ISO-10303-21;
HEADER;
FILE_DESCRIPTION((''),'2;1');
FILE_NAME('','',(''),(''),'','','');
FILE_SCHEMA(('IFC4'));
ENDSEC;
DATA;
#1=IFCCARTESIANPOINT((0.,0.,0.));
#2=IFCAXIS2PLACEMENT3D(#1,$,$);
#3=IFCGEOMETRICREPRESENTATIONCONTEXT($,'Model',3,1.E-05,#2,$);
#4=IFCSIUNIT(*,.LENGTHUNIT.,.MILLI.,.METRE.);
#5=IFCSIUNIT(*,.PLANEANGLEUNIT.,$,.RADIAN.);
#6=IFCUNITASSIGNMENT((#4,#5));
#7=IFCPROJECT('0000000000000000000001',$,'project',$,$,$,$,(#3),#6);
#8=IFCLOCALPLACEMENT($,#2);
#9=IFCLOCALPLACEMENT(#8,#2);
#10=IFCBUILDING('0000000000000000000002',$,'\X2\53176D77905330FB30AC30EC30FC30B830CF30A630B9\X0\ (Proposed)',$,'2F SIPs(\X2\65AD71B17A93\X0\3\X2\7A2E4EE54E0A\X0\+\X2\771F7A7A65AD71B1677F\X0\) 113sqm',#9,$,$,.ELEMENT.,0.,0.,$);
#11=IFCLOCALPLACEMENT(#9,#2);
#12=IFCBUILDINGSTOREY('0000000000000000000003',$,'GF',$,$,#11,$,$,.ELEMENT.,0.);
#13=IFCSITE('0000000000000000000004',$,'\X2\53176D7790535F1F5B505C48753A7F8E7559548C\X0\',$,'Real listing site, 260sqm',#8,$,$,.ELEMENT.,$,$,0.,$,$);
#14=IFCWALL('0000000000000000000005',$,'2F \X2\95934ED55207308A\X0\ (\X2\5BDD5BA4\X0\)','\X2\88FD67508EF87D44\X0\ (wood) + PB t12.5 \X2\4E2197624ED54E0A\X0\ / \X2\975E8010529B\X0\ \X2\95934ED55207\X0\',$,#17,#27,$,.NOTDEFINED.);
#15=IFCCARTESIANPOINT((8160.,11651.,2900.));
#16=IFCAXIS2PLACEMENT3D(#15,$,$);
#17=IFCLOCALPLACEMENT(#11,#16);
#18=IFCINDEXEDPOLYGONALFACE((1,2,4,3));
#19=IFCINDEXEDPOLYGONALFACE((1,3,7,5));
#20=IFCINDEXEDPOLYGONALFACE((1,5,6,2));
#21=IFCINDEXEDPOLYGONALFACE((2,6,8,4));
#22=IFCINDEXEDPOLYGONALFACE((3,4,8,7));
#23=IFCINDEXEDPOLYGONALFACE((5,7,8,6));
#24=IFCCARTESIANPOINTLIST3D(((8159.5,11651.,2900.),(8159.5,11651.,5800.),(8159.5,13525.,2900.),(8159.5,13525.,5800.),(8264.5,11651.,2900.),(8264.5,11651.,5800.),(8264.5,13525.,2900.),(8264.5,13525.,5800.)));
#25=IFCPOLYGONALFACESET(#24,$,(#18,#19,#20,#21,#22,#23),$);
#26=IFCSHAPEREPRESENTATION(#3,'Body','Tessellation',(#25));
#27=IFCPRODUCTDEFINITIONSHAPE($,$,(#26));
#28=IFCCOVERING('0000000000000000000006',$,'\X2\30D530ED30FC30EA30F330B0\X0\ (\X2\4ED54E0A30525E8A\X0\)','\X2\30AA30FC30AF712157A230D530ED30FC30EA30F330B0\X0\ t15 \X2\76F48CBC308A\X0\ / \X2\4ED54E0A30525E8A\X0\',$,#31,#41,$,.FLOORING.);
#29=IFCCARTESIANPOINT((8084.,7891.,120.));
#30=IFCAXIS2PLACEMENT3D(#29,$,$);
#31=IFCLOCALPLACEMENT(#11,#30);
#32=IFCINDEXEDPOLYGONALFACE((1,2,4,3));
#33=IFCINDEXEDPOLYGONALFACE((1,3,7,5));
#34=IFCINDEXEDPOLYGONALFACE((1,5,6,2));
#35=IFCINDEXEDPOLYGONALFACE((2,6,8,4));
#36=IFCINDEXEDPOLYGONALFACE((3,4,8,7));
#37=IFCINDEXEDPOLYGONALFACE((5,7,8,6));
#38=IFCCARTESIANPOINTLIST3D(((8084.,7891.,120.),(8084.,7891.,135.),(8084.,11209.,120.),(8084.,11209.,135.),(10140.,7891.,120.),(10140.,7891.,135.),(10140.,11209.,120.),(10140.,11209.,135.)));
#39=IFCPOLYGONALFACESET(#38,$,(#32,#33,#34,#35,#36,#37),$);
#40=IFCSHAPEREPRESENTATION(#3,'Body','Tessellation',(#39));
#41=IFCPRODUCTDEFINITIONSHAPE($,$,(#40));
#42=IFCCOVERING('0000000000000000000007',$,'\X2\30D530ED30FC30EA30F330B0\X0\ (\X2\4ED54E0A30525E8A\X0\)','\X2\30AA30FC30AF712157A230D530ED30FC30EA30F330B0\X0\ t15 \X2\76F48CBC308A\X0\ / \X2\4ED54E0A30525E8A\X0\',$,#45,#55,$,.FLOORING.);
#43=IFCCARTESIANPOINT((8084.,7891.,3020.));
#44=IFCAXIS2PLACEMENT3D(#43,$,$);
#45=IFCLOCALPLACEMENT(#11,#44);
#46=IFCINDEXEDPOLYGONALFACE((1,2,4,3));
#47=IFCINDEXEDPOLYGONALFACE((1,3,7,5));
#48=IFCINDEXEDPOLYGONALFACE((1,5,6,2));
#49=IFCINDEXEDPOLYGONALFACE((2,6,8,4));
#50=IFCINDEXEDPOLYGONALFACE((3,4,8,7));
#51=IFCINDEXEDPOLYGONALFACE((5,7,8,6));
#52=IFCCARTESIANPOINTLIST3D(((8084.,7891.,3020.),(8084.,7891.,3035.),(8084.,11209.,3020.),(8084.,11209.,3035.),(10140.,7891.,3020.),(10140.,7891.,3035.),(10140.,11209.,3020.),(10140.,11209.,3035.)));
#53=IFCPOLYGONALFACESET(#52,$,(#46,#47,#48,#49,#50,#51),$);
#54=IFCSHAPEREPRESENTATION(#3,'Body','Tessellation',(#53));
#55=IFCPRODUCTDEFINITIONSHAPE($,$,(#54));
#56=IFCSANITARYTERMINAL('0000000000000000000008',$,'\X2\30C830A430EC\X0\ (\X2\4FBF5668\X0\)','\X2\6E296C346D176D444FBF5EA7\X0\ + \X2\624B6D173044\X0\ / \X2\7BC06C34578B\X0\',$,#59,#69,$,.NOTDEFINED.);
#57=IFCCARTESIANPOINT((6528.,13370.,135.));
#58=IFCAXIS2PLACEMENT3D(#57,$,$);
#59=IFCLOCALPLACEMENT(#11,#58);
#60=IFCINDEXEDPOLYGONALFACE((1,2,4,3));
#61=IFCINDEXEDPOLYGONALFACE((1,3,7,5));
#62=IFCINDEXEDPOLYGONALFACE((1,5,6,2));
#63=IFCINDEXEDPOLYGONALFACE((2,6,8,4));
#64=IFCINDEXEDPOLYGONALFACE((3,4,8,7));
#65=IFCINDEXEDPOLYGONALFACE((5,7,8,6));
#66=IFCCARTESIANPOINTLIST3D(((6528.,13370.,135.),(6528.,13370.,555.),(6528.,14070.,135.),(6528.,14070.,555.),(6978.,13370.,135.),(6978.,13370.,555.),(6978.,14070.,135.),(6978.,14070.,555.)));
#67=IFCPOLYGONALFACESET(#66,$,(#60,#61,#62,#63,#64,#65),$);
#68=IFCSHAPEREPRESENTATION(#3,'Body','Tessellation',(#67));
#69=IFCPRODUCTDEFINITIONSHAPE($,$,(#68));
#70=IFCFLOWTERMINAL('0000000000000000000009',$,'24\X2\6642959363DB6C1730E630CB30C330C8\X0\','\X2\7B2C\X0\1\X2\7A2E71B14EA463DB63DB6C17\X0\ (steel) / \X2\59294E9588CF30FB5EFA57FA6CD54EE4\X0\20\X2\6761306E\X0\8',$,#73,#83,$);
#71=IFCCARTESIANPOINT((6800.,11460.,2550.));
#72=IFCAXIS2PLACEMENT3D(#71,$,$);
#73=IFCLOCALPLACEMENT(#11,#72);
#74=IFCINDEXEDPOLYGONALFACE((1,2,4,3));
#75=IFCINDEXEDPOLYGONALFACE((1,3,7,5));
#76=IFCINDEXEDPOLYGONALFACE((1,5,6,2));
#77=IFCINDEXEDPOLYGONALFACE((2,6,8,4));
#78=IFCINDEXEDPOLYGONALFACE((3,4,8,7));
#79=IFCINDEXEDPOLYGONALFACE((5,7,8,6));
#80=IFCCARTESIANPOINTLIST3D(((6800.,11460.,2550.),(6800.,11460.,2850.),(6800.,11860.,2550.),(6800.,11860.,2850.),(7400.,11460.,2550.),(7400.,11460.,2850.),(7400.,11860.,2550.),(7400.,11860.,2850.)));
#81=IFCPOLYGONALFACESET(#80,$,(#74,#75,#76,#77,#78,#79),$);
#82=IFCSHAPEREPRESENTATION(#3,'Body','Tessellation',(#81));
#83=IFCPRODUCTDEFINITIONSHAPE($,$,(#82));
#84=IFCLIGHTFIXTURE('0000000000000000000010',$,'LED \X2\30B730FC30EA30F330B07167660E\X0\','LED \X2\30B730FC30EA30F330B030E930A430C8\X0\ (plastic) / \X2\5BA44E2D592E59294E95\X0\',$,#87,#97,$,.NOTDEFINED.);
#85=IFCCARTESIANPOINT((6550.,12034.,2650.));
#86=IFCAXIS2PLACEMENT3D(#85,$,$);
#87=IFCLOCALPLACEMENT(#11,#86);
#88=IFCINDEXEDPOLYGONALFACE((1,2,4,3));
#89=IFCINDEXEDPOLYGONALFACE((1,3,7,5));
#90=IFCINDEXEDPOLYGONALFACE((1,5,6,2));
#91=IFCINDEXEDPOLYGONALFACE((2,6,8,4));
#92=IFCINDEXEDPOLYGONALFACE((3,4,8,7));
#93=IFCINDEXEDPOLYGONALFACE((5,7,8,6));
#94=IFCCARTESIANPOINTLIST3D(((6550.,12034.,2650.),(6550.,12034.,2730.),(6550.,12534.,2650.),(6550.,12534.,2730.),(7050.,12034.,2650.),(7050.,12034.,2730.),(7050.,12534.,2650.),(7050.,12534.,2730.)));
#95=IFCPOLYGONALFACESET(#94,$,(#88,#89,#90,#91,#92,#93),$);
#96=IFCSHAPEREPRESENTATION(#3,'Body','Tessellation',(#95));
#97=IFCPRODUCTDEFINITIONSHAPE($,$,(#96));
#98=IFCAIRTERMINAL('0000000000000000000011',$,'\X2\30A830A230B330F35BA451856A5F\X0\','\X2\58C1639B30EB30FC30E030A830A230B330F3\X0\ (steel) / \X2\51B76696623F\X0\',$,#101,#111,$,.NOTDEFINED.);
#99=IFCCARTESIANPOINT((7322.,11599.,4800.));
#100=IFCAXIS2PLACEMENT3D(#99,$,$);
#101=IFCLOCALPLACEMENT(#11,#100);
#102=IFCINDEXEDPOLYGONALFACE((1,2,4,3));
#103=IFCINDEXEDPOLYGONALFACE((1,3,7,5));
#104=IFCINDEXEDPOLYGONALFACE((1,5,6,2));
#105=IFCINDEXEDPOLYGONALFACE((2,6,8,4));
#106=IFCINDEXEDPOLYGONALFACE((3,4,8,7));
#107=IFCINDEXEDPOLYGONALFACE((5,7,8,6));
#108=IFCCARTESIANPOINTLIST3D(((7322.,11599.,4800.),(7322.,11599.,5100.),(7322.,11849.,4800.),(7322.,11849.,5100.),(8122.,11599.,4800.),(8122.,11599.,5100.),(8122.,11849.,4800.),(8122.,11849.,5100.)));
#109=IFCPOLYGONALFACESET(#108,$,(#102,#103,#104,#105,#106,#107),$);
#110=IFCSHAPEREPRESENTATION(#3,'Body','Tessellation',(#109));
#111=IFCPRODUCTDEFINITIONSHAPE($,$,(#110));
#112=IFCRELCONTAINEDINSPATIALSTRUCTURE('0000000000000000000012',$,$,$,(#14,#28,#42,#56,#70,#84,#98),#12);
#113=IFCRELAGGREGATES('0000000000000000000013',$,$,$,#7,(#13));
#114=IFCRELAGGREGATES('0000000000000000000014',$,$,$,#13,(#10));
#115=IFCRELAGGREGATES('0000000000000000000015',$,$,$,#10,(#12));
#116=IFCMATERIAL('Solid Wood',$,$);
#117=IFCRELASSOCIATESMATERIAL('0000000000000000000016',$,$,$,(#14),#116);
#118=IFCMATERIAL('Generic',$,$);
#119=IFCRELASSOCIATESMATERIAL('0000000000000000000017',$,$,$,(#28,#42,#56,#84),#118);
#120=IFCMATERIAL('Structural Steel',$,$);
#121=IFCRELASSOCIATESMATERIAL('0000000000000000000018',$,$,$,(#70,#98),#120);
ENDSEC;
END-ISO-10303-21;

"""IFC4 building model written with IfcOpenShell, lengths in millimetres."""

from ifc_helpers import new_model, si_unit, frame, frame_2d, origin, place, context, project, spatial, rectangle, extrude, material, element, save


model = new_model("IFC4")

# Units and contexts
model_context = context("Model", 3, precision=1e-05, world=origin())
ifc_project = project(units=[si_unit("LENGTHUNIT", "METRE", prefix="MILLI"), si_unit("PLANEANGLEUNIT", "RADIAN")], contexts=[model_context])

# Site, building, storey
site_placement = place(None, origin())
site = spatial("IfcSite", under=ifc_project, at=site_placement, Name="北海道弟子屈町美留和", ObjectType="Real listing site, 260sqm", CompositionType="ELEMENT", RefElevation=0.0)
building_placement = place(site_placement, origin())
building = spatial("IfcBuilding", under=site, at=building_placement, Name="北海道・ガレージハウス (Proposed)", ObjectType="2F SIPs(断熱窓3種以上+真空断熱板) 113sqm", CompositionType="ELEMENT", ElevationOfRefHeight=0.0, ElevationOfTerrain=0.0)
storey_placement = place(building_placement, origin())
storey = spatial("IfcBuildingStorey", under=building, at=storey_placement, Name="GF", CompositionType="ELEMENT", Elevation=0.0)

# Shared definitions
ifc_material_1 = material(Name="Solid Wood")

# Wall
wall_1_placement = place(storey_placement, frame((8160.0, 11651.0, 2900.0)))
element("IfcWall", 1, at=wall_1_placement, inside=storey, material=ifc_material_1, Name="2F 間仕切り (寝室)", Description="製材軸組 (wood) + PB t12.5 両面仕上 / 非耐力 間仕切", PredefinedType="NOTDEFINED", context=model_context, shape_type="SweptSolid", body=[
    extrude(rectangle(XDim=105.0, YDim=1874.0, at=frame_2d((52.0, 937.0))), frame((8160.0, 11651.0, 2900.0)), (0.0, 0.0, 1.0), 2900.0),
])

# Coverings
ifc_material_2 = material(Name="Generic")
covering_1_placement = place(storey_placement, frame((8084.0, 7891.0, 120.0)))
element("IfcCovering", 2, at=covering_1_placement, inside=storey, material=ifc_material_2, Name="フローリング (仕上げ床)", Description="オーク無垢フローリング t15 直貼り / 仕上げ床", PredefinedType="FLOORING", context=model_context, shape_type="SweptSolid", body=[
    extrude(rectangle(XDim=2056.0, YDim=3318.0, at=frame_2d((1028.0, 1659.0))), frame((8084.0, 7891.0, 120.0)), (0.0, 0.0, 1.0), 15.0),
])
covering_2_placement = place(storey_placement, frame((8084.0, 7891.0, 3020.0)))
element("IfcCovering", 3, at=covering_2_placement, inside=storey, material=ifc_material_2, Name="フローリング (仕上げ床)", Description="オーク無垢フローリング t15 直貼り / 仕上げ床", PredefinedType="FLOORING", context=model_context, shape_type="SweptSolid", body=[
    extrude(rectangle(XDim=2056.0, YDim=3318.0, at=frame_2d((1028.0, 1659.0))), frame((8084.0, 7891.0, 3020.0)), (0.0, 0.0, 1.0), 15.0),
])

# Sanitary terminal
sanitary_terminal_placement = place(storey_placement, frame((6528.0, 13370.0, 135.0)))
element("IfcSanitaryTerminal", 4, at=sanitary_terminal_placement, inside=storey, material=ifc_material_2, Name="トイレ (便器)", Description="温水洗浄便座 + 手洗い / 節水型", PredefinedType="NOTDEFINED", context=model_context, shape_type="SweptSolid", body=[
    extrude(rectangle(XDim=450.0, YDim=700.0, at=frame_2d((225.0, 350.0))), frame((6528.0, 13370.0, 135.0)), (0.0, 0.0, 1.0), 420.0),
])

# Flow terminal
ifc_material_3 = material(Name="Structural Steel")
flow_terminal_placement = place(storey_placement, frame((6800.0, 11460.0, 2550.0)))
element("IfcFlowTerminal", 5, at=flow_terminal_placement, inside=storey, material=ifc_material_3, Name="24時間換気ユニット", Description="第1種熱交換換気 (steel) / 天井裏・建基法令20条の8", context=model_context, shape_type="SweptSolid", body=[
    extrude(rectangle(XDim=600.0, YDim=400.0, at=frame_2d((300.0, 200.0))), frame((6800.0, 11460.0, 2550.0)), (0.0, 0.0, 1.0), 300.0),
])

# Light fixture
light_fixture_placement = place(storey_placement, frame((6550.0, 12034.0, 2650.0)))
element("IfcLightFixture", 6, at=light_fixture_placement, inside=storey, material=ifc_material_2, Name="LED シーリング照明", Description="LED シーリングライト (plastic) / 室中央天井", PredefinedType="NOTDEFINED", context=model_context, shape_type="SweptSolid", body=[
    extrude(rectangle(XDim=500.0, YDim=500.0, at=frame_2d((250.0, 250.0))), frame((6550.0, 12034.0, 2650.0)), (0.0, 0.0, 1.0), 80.0),
])

# Air terminal
air_terminal_placement = place(storey_placement, frame((7322.0, 11599.0, 4800.0)))
element("IfcAirTerminal", 7, at=air_terminal_placement, inside=storey, material=ifc_material_3, Name="エアコン室内機", Description="壁掛ルームエアコン (steel) / 冷暖房", PredefinedType="NOTDEFINED", context=model_context, shape_type="SweptSolid", body=[
    extrude(rectangle(XDim=800.0, YDim=250.0, at=frame_2d((400.0, 125.0))), frame((7322.0, 11599.0, 4800.0)), (0.0, 0.0, 1.0), 300.0),
])

save(model, "model.ifc")
